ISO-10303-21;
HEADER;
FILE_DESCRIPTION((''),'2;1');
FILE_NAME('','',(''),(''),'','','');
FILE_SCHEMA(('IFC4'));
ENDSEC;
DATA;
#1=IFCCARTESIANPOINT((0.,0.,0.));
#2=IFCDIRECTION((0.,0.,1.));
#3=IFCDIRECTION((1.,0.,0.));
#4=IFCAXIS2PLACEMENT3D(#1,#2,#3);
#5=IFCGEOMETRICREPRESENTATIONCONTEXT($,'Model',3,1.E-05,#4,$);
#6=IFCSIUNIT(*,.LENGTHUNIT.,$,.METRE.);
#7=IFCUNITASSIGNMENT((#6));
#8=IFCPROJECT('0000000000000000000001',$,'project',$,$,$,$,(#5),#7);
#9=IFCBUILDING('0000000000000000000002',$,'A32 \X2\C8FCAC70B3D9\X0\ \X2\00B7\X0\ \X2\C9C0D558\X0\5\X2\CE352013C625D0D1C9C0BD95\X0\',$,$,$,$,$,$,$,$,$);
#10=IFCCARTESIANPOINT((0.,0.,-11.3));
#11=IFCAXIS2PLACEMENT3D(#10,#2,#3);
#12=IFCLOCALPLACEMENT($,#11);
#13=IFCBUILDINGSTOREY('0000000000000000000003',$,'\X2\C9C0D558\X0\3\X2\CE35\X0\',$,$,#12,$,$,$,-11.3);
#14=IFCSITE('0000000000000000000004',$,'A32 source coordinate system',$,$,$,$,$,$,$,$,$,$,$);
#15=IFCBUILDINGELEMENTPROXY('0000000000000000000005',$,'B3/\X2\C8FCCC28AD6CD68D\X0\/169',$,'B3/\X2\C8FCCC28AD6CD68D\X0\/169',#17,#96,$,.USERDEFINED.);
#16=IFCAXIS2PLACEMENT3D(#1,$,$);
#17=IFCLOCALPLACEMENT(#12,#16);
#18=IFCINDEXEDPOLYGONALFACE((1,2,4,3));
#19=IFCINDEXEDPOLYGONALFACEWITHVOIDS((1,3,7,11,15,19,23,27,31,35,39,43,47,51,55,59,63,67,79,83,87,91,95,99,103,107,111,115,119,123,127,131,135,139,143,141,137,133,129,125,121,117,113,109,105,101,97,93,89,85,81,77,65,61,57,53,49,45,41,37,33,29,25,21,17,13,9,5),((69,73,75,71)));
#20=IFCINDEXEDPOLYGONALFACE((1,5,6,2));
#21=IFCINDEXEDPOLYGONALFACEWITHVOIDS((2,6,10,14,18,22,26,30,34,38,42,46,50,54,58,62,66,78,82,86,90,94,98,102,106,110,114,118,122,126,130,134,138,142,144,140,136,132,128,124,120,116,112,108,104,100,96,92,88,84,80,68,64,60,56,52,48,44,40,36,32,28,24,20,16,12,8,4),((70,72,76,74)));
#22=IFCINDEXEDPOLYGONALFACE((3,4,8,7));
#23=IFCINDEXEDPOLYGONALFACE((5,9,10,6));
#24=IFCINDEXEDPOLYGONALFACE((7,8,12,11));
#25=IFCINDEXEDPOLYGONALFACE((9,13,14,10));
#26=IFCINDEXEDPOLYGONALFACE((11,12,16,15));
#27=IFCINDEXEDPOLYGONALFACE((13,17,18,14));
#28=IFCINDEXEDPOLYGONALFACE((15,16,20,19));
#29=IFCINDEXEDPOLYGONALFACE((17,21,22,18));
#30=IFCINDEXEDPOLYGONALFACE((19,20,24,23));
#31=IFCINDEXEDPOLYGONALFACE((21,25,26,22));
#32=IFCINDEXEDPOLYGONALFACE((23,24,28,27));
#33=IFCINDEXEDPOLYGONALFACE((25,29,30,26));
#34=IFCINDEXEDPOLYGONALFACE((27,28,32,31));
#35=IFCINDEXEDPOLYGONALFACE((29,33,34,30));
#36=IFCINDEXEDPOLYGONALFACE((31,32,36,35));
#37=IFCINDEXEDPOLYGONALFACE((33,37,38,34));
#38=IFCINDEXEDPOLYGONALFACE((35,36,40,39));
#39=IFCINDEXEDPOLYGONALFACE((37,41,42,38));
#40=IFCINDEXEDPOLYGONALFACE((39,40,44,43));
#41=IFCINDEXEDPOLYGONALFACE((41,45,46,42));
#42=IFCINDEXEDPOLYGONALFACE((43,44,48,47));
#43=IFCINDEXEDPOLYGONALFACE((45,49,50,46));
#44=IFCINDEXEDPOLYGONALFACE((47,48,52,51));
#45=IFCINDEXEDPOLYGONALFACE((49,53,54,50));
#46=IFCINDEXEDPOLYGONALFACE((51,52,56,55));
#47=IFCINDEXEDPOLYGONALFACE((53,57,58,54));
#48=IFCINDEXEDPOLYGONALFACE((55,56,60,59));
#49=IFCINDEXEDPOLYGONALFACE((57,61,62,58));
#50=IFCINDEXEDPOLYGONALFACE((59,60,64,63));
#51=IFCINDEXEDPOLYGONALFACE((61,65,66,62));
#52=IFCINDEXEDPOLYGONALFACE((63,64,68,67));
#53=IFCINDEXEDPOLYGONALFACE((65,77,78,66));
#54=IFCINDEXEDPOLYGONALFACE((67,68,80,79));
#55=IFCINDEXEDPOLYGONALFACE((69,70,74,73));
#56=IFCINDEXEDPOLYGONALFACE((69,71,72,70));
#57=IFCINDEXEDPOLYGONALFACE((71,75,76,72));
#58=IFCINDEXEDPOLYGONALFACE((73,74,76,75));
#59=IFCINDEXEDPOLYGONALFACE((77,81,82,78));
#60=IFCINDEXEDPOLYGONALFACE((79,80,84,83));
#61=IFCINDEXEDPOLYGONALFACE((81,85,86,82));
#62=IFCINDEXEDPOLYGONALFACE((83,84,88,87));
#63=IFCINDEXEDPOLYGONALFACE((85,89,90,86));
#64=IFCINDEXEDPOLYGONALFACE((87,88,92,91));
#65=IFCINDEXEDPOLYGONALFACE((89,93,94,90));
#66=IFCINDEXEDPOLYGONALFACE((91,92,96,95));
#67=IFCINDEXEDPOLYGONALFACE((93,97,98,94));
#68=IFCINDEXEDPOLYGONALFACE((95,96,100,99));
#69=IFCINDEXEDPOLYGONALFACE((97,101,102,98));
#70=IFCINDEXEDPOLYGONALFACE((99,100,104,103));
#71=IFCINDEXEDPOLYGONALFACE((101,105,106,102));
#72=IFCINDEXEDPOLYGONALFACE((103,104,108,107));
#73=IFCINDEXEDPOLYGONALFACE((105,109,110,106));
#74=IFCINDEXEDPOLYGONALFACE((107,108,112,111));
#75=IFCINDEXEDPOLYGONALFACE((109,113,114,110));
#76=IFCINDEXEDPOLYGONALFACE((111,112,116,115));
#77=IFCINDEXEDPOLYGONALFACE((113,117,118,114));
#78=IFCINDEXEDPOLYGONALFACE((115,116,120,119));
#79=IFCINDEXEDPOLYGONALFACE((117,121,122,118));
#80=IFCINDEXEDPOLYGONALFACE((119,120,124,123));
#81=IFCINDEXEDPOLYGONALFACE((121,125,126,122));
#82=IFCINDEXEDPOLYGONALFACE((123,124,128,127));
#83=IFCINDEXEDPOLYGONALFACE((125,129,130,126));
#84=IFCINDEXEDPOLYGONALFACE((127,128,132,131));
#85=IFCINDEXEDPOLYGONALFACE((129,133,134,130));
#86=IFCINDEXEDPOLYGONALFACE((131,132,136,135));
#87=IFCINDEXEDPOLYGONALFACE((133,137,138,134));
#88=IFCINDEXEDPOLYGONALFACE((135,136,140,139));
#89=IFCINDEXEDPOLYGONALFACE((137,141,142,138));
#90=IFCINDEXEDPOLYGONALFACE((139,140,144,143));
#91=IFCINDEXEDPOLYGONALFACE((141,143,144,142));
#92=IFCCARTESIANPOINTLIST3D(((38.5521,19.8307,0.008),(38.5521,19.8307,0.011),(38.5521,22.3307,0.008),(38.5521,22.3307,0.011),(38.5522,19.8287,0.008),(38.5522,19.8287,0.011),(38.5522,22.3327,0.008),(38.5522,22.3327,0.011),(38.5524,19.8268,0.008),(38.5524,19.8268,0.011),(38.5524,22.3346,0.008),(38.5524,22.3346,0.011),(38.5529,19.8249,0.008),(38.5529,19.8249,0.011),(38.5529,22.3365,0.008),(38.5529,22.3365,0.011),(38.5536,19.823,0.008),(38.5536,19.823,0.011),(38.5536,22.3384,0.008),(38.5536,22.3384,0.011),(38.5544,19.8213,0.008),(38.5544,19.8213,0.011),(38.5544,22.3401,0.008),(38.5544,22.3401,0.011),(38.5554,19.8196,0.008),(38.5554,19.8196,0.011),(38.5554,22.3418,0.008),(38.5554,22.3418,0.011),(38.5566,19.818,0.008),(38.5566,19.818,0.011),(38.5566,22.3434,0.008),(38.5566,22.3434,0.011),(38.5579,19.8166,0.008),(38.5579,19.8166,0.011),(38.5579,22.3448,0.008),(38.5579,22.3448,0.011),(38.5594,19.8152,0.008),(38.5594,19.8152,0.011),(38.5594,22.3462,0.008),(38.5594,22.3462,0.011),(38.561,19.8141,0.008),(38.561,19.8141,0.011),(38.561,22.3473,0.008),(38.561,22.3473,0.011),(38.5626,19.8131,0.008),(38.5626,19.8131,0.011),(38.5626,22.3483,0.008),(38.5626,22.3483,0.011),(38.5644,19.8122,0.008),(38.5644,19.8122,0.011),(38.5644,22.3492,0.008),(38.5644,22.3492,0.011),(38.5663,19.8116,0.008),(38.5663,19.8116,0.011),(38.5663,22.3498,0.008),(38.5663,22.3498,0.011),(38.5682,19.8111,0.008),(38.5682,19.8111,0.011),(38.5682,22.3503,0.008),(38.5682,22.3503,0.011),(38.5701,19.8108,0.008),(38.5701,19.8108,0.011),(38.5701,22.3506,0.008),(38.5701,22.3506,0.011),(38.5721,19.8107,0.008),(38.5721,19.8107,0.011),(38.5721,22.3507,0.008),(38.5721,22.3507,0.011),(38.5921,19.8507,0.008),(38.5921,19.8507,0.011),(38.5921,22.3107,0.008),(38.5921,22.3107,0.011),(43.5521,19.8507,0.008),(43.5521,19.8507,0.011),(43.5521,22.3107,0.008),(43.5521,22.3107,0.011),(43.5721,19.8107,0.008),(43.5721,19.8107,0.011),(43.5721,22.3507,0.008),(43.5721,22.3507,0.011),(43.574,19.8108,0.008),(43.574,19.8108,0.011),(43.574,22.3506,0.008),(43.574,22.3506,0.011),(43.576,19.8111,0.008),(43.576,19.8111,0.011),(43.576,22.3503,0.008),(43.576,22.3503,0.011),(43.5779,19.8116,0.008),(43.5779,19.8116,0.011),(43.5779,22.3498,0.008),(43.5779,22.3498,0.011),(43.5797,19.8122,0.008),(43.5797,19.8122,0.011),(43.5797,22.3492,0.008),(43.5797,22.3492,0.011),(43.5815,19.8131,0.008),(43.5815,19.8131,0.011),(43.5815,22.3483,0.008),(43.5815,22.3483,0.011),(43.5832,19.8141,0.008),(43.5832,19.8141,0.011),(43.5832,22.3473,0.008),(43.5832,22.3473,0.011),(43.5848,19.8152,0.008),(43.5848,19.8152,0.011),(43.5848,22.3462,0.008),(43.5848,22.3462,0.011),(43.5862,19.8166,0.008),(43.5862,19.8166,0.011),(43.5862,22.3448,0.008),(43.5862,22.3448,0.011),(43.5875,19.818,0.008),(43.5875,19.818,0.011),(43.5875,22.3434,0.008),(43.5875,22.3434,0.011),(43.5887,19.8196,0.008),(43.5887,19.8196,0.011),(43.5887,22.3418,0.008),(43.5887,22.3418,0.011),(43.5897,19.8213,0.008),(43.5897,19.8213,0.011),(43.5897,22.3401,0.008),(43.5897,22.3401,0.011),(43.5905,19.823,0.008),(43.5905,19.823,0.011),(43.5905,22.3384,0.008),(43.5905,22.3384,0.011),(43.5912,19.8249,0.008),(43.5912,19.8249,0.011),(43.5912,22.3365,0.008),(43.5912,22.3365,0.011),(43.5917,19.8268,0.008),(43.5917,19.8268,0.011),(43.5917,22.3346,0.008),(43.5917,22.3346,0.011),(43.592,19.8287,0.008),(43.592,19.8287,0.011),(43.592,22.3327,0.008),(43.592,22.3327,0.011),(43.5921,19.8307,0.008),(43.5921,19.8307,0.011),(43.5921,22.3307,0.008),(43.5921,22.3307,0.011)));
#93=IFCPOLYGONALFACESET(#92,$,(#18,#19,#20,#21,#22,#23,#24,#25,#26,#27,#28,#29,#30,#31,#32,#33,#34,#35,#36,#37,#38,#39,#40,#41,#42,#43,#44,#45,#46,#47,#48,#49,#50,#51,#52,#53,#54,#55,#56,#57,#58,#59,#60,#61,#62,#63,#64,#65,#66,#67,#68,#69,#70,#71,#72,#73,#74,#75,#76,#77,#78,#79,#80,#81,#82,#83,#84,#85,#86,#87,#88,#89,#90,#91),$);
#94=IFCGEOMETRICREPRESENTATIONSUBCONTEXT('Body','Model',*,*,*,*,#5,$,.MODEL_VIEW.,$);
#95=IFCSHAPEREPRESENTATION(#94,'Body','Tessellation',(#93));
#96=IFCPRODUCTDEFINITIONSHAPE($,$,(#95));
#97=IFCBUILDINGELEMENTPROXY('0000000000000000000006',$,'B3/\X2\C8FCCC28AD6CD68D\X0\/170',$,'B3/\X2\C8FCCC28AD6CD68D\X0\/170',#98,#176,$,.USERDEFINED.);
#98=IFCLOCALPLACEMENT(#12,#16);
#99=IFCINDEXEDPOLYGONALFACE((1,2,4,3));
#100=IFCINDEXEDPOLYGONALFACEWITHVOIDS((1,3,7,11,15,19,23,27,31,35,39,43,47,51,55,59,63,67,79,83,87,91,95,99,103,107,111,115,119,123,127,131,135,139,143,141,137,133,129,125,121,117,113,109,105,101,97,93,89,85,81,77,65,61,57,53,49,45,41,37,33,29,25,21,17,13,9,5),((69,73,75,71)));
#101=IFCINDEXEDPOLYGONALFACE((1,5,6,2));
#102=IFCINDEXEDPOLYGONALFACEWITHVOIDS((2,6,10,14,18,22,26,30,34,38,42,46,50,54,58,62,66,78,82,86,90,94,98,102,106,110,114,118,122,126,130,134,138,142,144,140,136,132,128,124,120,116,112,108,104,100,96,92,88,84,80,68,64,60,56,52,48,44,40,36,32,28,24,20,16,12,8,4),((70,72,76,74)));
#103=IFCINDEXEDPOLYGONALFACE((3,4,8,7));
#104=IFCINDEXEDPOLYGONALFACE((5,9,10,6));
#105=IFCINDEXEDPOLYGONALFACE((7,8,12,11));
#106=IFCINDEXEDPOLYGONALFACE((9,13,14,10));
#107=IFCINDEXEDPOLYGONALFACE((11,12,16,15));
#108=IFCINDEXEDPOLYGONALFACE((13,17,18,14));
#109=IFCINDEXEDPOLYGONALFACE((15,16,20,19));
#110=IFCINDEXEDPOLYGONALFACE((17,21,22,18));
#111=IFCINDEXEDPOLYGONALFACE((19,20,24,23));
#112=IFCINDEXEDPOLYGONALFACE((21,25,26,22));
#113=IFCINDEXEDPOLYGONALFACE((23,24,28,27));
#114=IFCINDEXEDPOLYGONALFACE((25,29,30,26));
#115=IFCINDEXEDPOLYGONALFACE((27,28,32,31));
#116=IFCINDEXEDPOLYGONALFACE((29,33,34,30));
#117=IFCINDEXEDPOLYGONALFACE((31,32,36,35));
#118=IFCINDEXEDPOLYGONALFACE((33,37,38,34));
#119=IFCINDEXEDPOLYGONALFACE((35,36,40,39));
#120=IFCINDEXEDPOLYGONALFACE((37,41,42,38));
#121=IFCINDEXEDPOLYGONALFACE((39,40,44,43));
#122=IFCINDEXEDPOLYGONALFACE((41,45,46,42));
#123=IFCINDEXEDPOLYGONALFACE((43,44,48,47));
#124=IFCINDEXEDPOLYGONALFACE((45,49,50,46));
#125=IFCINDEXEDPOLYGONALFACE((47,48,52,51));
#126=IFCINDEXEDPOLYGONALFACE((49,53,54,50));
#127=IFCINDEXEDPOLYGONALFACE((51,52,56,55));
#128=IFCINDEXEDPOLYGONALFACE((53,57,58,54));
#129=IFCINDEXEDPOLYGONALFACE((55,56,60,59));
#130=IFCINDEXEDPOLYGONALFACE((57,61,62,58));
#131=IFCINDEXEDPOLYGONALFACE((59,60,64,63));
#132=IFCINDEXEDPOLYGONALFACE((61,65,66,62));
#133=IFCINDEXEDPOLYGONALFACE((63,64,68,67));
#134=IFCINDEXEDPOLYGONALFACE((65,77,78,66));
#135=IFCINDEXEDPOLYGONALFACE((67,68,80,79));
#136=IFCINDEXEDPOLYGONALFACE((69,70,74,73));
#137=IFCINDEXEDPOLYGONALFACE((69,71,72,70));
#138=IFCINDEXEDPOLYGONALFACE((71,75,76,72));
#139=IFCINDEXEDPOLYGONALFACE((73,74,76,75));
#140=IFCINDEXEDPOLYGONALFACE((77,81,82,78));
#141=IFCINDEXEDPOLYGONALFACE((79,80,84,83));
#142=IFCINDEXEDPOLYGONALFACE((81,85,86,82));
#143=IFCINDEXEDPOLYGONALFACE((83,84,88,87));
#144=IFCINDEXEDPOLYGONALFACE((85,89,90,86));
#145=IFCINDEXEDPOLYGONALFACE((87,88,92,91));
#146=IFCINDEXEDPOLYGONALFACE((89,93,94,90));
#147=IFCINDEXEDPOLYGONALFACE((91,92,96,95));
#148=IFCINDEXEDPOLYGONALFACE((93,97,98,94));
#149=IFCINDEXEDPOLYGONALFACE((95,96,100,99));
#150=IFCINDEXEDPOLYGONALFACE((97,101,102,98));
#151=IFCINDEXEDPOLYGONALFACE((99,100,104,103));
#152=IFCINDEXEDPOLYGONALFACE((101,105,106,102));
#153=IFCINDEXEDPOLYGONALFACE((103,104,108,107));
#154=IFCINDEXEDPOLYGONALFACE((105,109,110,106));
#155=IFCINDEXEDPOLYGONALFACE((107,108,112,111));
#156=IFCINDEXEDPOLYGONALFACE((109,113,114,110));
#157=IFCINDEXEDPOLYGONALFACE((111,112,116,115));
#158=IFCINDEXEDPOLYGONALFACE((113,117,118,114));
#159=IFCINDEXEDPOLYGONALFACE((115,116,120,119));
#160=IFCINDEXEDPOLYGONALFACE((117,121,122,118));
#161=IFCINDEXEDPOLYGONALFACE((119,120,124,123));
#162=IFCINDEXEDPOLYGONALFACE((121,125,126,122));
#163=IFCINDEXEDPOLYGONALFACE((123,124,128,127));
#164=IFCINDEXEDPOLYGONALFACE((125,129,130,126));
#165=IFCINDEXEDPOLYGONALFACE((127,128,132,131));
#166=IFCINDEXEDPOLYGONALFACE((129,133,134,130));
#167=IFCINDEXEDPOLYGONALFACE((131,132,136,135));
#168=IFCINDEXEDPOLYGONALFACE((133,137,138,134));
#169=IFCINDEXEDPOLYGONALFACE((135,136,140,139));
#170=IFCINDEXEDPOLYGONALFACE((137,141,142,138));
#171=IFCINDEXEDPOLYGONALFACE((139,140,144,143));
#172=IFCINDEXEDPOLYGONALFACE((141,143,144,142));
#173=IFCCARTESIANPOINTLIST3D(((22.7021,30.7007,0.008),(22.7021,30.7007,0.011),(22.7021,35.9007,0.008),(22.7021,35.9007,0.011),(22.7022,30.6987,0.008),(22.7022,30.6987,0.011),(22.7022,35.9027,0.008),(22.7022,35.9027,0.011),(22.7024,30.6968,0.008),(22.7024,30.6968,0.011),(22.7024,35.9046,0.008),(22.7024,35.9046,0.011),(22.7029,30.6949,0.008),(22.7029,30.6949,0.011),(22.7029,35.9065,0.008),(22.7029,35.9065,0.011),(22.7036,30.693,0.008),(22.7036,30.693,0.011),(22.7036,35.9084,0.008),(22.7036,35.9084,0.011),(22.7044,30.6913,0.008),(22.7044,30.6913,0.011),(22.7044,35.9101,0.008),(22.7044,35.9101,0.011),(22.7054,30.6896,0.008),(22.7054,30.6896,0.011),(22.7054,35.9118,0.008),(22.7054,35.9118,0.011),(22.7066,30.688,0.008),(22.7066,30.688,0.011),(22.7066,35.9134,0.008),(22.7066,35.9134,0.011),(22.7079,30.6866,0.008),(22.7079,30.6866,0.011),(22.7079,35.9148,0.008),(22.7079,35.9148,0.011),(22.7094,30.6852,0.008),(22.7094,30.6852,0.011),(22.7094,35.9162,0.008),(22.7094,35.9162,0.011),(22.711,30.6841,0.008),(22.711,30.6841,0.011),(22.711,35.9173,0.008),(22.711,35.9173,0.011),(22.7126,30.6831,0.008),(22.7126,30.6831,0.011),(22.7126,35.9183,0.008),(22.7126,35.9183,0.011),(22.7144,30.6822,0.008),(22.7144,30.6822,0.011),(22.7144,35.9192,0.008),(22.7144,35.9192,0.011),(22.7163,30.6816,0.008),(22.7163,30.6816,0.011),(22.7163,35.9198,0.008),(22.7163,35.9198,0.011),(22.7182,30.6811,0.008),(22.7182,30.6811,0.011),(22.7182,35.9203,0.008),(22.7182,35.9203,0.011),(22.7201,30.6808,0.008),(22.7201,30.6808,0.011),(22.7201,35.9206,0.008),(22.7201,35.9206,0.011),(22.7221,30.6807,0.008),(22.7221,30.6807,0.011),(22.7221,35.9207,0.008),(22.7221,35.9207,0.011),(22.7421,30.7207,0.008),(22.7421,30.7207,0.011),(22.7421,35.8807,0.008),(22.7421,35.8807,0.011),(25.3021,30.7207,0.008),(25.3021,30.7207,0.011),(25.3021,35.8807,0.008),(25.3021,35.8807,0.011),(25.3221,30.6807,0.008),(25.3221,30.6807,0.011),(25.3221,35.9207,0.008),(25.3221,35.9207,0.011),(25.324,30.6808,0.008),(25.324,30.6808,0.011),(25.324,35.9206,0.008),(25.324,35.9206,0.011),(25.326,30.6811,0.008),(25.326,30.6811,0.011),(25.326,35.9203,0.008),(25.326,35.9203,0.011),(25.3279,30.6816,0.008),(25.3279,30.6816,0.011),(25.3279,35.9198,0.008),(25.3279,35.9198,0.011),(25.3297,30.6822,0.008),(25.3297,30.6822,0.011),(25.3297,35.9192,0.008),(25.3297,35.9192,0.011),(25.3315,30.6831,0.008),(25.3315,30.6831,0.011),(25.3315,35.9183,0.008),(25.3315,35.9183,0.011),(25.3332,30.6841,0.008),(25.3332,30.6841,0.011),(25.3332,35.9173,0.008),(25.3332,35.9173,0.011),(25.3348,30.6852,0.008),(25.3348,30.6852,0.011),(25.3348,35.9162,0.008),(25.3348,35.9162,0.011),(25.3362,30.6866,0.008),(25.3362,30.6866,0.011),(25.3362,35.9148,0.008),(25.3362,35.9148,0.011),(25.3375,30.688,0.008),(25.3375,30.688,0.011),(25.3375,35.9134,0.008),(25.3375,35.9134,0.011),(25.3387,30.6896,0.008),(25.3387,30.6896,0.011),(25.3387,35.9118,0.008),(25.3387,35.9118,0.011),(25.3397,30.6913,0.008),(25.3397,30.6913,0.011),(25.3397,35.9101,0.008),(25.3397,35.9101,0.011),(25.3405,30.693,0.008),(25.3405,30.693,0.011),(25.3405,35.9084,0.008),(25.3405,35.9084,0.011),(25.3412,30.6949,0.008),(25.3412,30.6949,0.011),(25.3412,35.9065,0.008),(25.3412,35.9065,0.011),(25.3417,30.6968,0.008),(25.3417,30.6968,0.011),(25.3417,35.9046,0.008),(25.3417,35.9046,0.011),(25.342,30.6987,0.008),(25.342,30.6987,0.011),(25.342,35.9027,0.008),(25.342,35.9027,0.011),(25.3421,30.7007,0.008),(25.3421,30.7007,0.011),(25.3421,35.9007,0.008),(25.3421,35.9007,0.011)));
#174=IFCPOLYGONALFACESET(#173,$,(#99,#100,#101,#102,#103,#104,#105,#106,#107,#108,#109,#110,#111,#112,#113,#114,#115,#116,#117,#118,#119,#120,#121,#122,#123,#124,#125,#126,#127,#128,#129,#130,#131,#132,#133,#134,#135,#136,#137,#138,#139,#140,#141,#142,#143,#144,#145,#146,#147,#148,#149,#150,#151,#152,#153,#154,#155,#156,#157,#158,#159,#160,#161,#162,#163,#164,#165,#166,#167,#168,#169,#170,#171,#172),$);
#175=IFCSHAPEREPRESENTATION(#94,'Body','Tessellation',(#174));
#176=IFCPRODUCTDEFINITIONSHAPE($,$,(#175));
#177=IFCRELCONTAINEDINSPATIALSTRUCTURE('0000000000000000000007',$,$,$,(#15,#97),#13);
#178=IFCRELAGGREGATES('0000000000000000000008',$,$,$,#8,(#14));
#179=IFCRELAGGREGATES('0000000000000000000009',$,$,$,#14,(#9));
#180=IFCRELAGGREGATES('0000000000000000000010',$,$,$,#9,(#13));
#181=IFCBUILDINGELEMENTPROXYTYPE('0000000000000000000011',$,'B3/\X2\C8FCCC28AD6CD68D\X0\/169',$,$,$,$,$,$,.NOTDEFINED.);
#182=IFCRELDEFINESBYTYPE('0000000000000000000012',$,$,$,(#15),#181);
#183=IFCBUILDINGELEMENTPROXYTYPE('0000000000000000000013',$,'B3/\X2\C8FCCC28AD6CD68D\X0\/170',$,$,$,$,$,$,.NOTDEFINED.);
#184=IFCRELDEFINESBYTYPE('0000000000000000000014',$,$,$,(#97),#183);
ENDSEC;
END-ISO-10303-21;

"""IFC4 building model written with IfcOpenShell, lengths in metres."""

from ifc_helpers import new_model, si_unit, frame, origin, origin_with_axes, place, context, subcontext, project, spatial, polyline, outline, extrude, source, transform, mapped, type_object, type_shapes, element, save


model = new_model("IFC4")

# Units and contexts
model_context = context("Model", 3, precision=1e-05, world=origin_with_axes())
body_context = subcontext(model_context, "Body", "Model", "MODEL_VIEW")
ifc_project = project(units=[si_unit("LENGTHUNIT", "METRE")], contexts=[model_context])

# Site, building, storey
site = spatial("IfcSite", under=ifc_project, Name="A32 source coordinate system")
building = spatial("IfcBuilding", under=site, Name="A32 주거동 · 지하5층–옥탑지붕")
storey_placement = place(None, frame((0.0, 0.0, -11.3), z_axis=(0.0, 0.0, 1.0), x_axis=(1.0, 0.0, 0.0)))
storey = spatial("IfcBuildingStorey", under=building, at=storey_placement, Name="지하3층", Elevation=-11.3)

# Building element proxies
building_element_proxy_type_1 = type_object("IfcBuildingElementProxyType", Name="B3/주차구획/169", PredefinedType="NOTDEFINED")
shared_shape_1 = source(origin(), body_context, "Body", "SweptSolid", [
    extrude(outline(polyline([(43.5721, 22.3507), (43.574, 22.3506), (43.576, 22.3503), (43.5779, 22.3498), (43.5797, 22.3492), (43.5815, 22.3483), (43.5832, 22.3473), (43.5848, 22.3462), (43.5862, 22.3448), (43.5875, 22.3434), (43.5887, 22.3418), (43.5897, 22.3401), (43.5905, 22.3384), (43.5912, 22.3365), (43.5917, 22.3346), (43.592, 22.3327), (43.5921, 22.3307), (43.5921, 19.8307), (43.592, 19.8287), (43.5917, 19.8268), (43.5912, 19.8249), (43.5905, 19.823), (43.5897, 19.8213), (43.5887, 19.8196), (43.5875, 19.818), (43.5862, 19.8166), (43.5848, 19.8152), (43.5832, 19.8141), (43.5815, 19.8131), (43.5797, 19.8122), (43.5779, 19.8116), (43.576, 19.8111), (43.574, 19.8108), (43.5721, 19.8107), (38.5721, 19.8107), (38.5701, 19.8108), (38.5682, 19.8111), (38.5663, 19.8116), (38.5644, 19.8122), (38.5626, 19.8131), (38.561, 19.8141), (38.5594, 19.8152), (38.5579, 19.8166), (38.5566, 19.818), (38.5554, 19.8196), (38.5544, 19.8213), (38.5536, 19.823), (38.5529, 19.8249), (38.5524, 19.8268), (38.5522, 19.8287), (38.5521, 19.8307), (38.5521, 22.3307), (38.5522, 22.3327), (38.5524, 22.3346), (38.5529, 22.3365), (38.5536, 22.3384), (38.5544, 22.3401), (38.5554, 22.3418), (38.5566, 22.3434), (38.5579, 22.3448), (38.5594, 22.3462), (38.561, 22.3473), (38.5626, 22.3483), (38.5644, 22.3492), (38.5663, 22.3498), (38.5682, 22.3503), (38.5701, 22.3506), (38.5721, 22.3507), (43.5721, 22.3507)]), holes=[polyline([(43.5521, 22.3107), (38.5921, 22.3107), (38.5921, 19.8507), (43.5521, 19.8507), (43.5521, 22.3107)])]), frame((0.0, 0.0, 0.008)), (0.0, 0.0, 1.0), 0.003),
])
type_shapes(building_element_proxy_type_1, [shared_shape_1])
proxy_1_placement = place(storey_placement, origin_with_axes())
element("IfcBuildingElementProxy", 1, at=proxy_1_placement, inside=storey, type_object=building_element_proxy_type_1, Name="B3/주차구획/169", ObjectType="B3/주차구획/169", PredefinedType="USERDEFINED", context=body_context, shape_type="MappedRepresentation", body=[
    mapped(shared_shape_1, transform((0.0, 0.0, 0.0), scale=1.0)),
])
building_element_proxy_type_2 = type_object("IfcBuildingElementProxyType", Name="B3/주차구획/170", PredefinedType="NOTDEFINED")
shared_shape_2 = source(origin(), body_context, "Body", "SweptSolid", [
    extrude(outline(polyline([(22.7021, 35.9007), (22.7022, 35.9027), (22.7024, 35.9046), (22.7029, 35.9065), (22.7036, 35.9084), (22.7044, 35.9101), (22.7054, 35.9118), (22.7066, 35.9134), (22.7079, 35.9148), (22.7094, 35.9162), (22.711, 35.9173), (22.7126, 35.9183), (22.7144, 35.9192), (22.7163, 35.9198), (22.7182, 35.9203), (22.7201, 35.9206), (22.7221, 35.9207), (25.3221, 35.9207), (25.324, 35.9206), (25.326, 35.9203), (25.3279, 35.9198), (25.3297, 35.9192), (25.3315, 35.9183), (25.3332, 35.9173), (25.3348, 35.9162), (25.3362, 35.9148), (25.3375, 35.9134), (25.3387, 35.9118), (25.3397, 35.9101), (25.3405, 35.9084), (25.3412, 35.9065), (25.3417, 35.9046), (25.342, 35.9027), (25.3421, 35.9007), (25.3421, 30.7007), (25.342, 30.6987), (25.3417, 30.6968), (25.3412, 30.6949), (25.3405, 30.693), (25.3397, 30.6913), (25.3387, 30.6896), (25.3375, 30.688), (25.3362, 30.6866), (25.3348, 30.6852), (25.3332, 30.6841), (25.3315, 30.6831), (25.3297, 30.6822), (25.3279, 30.6816), (25.326, 30.6811), (25.324, 30.6808), (25.3221, 30.6807), (22.7221, 30.6807), (22.7201, 30.6808), (22.7182, 30.6811), (22.7163, 30.6816), (22.7144, 30.6822), (22.7126, 30.6831), (22.711, 30.6841), (22.7094, 30.6852), (22.7079, 30.6866), (22.7066, 30.688), (22.7054, 30.6896), (22.7044, 30.6913), (22.7036, 30.693), (22.7029, 30.6949), (22.7024, 30.6968), (22.7022, 30.6987), (22.7021, 30.7007), (22.7021, 35.9007)]), holes=[polyline([(22.7421, 35.8807), (22.7421, 30.7207), (25.3021, 30.7207), (25.3021, 35.8807), (22.7421, 35.8807)])]), frame((0.0, 0.0, 0.008)), (0.0, 0.0, 1.0), 0.003),
])
type_shapes(building_element_proxy_type_2, [shared_shape_2])
proxy_2_placement = place(storey_placement, origin_with_axes())
element("IfcBuildingElementProxy", 2, at=proxy_2_placement, inside=storey, type_object=building_element_proxy_type_2, Name="B3/주차구획/170", ObjectType="B3/주차구획/170", PredefinedType="USERDEFINED", context=body_context, shape_type="MappedRepresentation", body=[
    mapped(shared_shape_2, transform((0.0, 0.0, 0.0), scale=1.0)),
])

save(model, "model.ifc")
